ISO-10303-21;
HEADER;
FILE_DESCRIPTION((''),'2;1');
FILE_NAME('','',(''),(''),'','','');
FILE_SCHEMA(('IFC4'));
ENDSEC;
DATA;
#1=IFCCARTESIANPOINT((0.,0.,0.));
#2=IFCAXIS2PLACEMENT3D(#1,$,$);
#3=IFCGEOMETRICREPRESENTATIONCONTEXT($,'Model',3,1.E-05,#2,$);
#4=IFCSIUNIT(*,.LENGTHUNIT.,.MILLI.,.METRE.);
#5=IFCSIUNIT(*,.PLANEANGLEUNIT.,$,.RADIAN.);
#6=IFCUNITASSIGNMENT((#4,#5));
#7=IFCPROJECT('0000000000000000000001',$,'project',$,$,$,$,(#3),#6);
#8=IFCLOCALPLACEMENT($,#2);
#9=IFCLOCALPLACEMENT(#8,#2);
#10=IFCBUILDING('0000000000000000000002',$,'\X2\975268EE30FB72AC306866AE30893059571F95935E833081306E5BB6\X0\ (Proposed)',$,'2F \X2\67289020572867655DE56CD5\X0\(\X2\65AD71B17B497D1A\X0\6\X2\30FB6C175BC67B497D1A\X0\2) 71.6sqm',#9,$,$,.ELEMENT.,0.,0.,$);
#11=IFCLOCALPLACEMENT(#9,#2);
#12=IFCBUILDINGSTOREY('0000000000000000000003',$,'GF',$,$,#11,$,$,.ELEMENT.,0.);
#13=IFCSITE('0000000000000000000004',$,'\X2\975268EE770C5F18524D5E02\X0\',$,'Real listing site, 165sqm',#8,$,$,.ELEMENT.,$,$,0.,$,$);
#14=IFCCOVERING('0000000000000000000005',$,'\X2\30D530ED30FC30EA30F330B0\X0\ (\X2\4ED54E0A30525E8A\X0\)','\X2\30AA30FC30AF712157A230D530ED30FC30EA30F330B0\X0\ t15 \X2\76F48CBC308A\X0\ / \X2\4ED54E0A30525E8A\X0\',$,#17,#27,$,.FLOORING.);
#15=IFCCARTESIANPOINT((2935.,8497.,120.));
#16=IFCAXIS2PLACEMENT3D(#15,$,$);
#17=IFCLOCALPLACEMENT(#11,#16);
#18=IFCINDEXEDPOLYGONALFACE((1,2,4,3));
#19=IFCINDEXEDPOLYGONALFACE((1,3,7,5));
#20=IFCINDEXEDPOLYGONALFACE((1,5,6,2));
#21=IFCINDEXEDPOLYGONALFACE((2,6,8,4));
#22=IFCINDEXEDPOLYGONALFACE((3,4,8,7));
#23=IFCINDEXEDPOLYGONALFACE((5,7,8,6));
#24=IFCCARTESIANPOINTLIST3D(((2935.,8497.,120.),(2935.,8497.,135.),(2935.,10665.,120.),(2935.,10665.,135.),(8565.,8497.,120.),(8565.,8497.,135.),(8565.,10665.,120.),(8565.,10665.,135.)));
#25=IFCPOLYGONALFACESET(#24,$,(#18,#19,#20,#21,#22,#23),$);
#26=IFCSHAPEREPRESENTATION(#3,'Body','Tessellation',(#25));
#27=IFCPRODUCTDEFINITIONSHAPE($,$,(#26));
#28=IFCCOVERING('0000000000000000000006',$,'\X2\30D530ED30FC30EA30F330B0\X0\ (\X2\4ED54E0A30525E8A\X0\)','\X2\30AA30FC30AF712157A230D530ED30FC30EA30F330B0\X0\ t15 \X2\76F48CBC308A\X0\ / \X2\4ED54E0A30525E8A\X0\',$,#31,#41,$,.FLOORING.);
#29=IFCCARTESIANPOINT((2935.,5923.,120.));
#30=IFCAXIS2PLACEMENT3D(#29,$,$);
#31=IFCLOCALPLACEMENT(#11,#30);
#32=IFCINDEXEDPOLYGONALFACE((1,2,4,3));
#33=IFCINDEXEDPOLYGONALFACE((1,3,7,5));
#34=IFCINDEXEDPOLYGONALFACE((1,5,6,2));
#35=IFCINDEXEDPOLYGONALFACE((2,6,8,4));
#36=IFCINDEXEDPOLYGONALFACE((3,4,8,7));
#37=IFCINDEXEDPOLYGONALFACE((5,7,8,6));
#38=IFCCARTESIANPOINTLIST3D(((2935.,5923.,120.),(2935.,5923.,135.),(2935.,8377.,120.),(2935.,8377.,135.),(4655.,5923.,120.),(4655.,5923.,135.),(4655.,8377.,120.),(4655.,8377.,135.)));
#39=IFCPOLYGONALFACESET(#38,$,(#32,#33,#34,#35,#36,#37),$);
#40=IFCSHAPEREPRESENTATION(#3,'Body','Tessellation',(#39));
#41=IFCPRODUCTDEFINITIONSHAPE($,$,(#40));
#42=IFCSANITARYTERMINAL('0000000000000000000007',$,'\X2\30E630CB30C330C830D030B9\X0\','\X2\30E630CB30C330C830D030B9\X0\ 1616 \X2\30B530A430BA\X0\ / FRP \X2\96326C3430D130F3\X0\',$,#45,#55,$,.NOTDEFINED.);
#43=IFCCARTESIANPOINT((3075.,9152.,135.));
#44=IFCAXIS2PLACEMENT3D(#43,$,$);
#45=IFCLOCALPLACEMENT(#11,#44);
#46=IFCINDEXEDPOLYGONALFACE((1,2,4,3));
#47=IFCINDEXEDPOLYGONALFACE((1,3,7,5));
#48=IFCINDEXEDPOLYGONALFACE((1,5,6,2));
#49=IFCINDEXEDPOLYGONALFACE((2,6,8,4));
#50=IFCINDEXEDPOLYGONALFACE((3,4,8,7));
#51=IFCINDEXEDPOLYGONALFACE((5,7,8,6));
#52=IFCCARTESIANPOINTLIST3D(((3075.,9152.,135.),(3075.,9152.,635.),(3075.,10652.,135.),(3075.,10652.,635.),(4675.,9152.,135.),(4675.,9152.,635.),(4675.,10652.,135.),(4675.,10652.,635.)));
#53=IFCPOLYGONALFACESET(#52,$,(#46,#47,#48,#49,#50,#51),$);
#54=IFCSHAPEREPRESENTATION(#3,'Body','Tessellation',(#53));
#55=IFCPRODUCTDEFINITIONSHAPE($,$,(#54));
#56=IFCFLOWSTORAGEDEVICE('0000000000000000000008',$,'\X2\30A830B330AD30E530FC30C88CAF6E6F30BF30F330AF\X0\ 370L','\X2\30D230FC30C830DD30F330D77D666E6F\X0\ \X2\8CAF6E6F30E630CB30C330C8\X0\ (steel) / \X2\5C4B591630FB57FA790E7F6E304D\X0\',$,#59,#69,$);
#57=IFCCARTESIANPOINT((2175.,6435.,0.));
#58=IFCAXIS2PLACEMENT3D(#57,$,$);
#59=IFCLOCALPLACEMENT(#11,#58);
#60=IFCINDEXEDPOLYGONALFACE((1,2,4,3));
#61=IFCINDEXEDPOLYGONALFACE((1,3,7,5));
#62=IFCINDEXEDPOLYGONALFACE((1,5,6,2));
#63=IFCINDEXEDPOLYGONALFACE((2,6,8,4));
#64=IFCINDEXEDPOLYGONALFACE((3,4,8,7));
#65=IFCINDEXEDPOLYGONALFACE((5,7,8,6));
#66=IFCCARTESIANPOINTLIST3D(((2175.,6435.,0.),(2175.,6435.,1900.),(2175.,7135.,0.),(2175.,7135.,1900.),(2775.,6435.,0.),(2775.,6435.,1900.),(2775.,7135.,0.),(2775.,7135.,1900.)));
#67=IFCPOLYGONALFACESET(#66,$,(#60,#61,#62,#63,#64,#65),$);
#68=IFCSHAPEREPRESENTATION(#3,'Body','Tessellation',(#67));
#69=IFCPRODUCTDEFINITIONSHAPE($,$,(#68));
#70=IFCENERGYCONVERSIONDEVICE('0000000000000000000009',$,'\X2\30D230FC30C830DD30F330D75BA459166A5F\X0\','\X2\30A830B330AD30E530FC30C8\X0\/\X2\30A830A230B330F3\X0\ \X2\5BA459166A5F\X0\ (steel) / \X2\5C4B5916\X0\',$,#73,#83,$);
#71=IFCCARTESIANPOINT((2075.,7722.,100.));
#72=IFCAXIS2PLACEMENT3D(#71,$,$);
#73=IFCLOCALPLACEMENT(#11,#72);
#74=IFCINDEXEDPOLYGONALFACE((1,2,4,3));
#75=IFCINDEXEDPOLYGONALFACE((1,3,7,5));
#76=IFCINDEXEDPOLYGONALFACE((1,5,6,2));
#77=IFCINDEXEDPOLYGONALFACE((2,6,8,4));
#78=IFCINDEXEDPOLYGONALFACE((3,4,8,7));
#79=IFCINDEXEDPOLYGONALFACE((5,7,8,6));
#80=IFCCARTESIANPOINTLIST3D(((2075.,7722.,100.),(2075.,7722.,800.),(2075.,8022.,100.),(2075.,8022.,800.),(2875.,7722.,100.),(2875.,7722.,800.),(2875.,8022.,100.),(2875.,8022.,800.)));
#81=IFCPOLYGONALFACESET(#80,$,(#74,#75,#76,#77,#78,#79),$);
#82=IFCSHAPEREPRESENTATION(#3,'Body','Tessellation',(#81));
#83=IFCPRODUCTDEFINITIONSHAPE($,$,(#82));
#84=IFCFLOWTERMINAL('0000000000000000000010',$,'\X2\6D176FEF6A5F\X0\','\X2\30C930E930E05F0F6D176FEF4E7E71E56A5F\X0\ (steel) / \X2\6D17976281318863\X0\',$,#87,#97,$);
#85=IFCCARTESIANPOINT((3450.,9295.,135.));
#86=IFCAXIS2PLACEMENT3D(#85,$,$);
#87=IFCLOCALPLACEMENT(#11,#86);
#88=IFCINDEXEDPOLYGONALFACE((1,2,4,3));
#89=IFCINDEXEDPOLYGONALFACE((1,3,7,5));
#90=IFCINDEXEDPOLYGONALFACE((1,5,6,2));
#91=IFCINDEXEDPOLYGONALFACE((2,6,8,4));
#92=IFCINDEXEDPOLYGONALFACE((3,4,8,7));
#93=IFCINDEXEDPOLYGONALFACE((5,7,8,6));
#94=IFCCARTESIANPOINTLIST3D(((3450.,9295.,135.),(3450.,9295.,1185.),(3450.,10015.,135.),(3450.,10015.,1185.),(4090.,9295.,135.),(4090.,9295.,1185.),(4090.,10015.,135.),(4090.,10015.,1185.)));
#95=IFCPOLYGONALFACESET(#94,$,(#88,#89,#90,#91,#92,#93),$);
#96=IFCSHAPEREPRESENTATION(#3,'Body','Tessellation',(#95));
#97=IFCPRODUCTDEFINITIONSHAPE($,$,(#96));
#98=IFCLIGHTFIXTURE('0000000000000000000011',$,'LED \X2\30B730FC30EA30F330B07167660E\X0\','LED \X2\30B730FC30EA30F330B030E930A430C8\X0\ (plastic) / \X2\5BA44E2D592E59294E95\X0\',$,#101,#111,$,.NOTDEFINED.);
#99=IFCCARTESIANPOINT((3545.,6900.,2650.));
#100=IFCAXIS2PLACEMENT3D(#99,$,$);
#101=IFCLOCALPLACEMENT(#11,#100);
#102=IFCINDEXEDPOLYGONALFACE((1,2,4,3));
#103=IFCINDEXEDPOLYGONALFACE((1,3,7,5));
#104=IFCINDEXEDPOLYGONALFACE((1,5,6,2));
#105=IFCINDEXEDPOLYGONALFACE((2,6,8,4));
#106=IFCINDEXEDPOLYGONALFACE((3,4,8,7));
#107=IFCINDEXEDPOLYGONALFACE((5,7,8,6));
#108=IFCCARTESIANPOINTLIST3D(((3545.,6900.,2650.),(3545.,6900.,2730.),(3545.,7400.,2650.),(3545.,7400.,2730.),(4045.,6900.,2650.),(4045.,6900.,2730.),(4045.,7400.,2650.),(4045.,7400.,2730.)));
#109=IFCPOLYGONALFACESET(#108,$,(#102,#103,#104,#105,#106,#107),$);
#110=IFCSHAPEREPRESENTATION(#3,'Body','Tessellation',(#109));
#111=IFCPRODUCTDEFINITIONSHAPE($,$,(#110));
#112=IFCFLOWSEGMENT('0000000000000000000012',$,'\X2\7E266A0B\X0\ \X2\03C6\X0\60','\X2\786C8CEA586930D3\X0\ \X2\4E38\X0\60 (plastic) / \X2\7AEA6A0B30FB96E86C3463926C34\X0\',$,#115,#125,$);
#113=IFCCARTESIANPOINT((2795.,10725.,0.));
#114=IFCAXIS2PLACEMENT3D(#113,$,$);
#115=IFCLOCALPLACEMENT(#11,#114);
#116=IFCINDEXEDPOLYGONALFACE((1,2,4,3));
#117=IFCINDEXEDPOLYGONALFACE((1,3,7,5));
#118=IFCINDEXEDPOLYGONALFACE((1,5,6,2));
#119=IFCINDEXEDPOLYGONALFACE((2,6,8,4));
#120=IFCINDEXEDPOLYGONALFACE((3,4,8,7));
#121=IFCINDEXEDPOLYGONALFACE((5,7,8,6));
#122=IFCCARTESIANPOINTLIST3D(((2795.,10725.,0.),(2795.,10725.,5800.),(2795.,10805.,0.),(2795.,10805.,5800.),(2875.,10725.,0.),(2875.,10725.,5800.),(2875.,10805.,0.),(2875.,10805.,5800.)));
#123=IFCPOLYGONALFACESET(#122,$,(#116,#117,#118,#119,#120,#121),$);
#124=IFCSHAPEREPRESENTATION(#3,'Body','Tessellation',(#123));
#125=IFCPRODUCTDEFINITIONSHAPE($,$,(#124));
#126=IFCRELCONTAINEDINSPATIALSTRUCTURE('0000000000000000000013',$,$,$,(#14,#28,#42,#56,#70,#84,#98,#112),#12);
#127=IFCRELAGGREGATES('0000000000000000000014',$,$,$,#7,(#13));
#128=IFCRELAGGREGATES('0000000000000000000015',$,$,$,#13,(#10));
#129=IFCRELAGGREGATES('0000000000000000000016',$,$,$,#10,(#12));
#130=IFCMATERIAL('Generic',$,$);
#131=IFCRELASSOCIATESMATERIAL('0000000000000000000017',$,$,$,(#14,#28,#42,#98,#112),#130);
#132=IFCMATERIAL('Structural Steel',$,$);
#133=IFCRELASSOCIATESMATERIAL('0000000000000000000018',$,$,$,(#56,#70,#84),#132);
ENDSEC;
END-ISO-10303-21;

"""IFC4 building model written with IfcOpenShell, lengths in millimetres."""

from ifc_helpers import new_model, si_unit, frame, frame_2d, origin, place, context, project, spatial, rectangle, extrude, material, element, save


model = new_model("IFC4")

# Units and contexts
model_context = context("Model", 3, precision=1e-05, world=origin())
ifc_project = project(units=[si_unit("LENGTHUNIT", "METRE", prefix="MILLI"), si_unit("PLANEANGLEUNIT", "RADIAN")], contexts=[model_context])

# Site, building, storey
site_placement = place(None, origin())
site = spatial("IfcSite", under=ifc_project, at=site_placement, Name="青森県弘前市", ObjectType="Real listing site, 165sqm", CompositionType="ELEMENT", RefElevation=0.0)
building_placement = place(site_placement, origin())
building = spatial("IfcBuilding", under=site, at=building_placement, Name="青森・犬と暮らす土間広めの家 (Proposed)", ObjectType="2F 木造在来工法(断熱等級6・気密等級2) 71.6sqm", CompositionType="ELEMENT", ElevationOfRefHeight=0.0, ElevationOfTerrain=0.0)
storey_placement = place(building_placement, origin())
storey = spatial("IfcBuildingStorey", under=building, at=storey_placement, Name="GF", CompositionType="ELEMENT", Elevation=0.0)

# Coverings
ifc_material_1 = material(Name="Generic")
covering_1_placement = place(storey_placement, frame((2935.0, 8497.0, 120.0)))
element("IfcCovering", 1, at=covering_1_placement, inside=storey, material=ifc_material_1, Name="フローリング (仕上げ床)", Description="オーク無垢フローリング t15 直貼り / 仕上げ床", PredefinedType="FLOORING", context=model_context, shape_type="SweptSolid", body=[
    extrude(rectangle(XDim=5630.0, YDim=2168.0, at=frame_2d((2815.0, 1084.0))), frame((2935.0, 8497.0, 120.0)), (0.0, 0.0, 1.0), 15.0),
])
covering_2_placement = place(storey_placement, frame((2935.0, 5923.0, 120.0)))
element("IfcCovering", 2, at=covering_2_placement, inside=storey, material=ifc_material_1, Name="フローリング (仕上げ床)", Description="オーク無垢フローリング t15 直貼り / 仕上げ床", PredefinedType="FLOORING", context=model_context, shape_type="SweptSolid", body=[
    extrude(rectangle(XDim=1720.0, YDim=2454.0, at=frame_2d((860.0, 1227.0))), frame((2935.0, 5923.0, 120.0)), (0.0, 0.0, 1.0), 15.0),
])

# Sanitary terminal
sanitary_terminal_placement = place(storey_placement, frame((3075.0, 9152.0, 135.0)))
element("IfcSanitaryTerminal", 3, at=sanitary_terminal_placement, inside=storey, material=ifc_material_1, Name="ユニットバス", Description="ユニットバス 1616 サイズ / FRP 防水パン", PredefinedType="NOTDEFINED", context=model_context, shape_type="SweptSolid", body=[
    extrude(rectangle(XDim=1600.0, YDim=1500.0, at=frame_2d((800.0, 750.0))), frame((3075.0, 9152.0, 135.0)), (0.0, 0.0, 1.0), 500.0),
])

# Flow storage device
ifc_material_2 = material(Name="Structural Steel")
flow_storage_device_placement = place(storey_placement, frame((2175.0, 6435.0, 0.0)))
element("IfcFlowStorageDevice", 4, at=flow_storage_device_placement, inside=storey, material=ifc_material_2, Name="エコキュート貯湯タンク 370L", Description="ヒートポンプ給湯 貯湯ユニット (steel) / 屋外・基礎置き", context=model_context, shape_type="SweptSolid", body=[
    extrude(rectangle(XDim=600.0, YDim=700.0, at=frame_2d((300.0, 350.0))), frame((2175.0, 6435.0, 0.0)), (0.0, 0.0, 1.0), 1900.0),
])

# Energy conversion device
energy_conversion_device_placement = place(storey_placement, frame((2075.0, 7722.0, 100.0)))
element("IfcEnergyConversionDevice", 5, at=energy_conversion_device_placement, inside=storey, material=ifc_material_2, Name="ヒートポンプ室外機", Description="エコキュート/エアコン 室外機 (steel) / 屋外", context=model_context, shape_type="SweptSolid", body=[
    extrude(rectangle(XDim=800.0, YDim=300.0, at=frame_2d((400.0, 150.0))), frame((2075.0, 7722.0, 100.0)), (0.0, 0.0, 1.0), 700.0),
])

# Flow terminal
flow_terminal_placement = place(storey_placement, frame((3450.0, 9295.0, 135.0)))
element("IfcFlowTerminal", 6, at=flow_terminal_placement, inside=storey, material=ifc_material_2, Name="洗濯機", Description="ドラム式洗濯乾燥機 (steel) / 洗面脱衣", context=model_context, shape_type="SweptSolid", body=[
    extrude(rectangle(XDim=640.0, YDim=720.0, at=frame_2d((320.0, 360.0))), frame((3450.0, 9295.0, 135.0)), (0.0, 0.0, 1.0), 1050.0),
])

# Light fixture
light_fixture_placement = place(storey_placement, frame((3545.0, 6900.0, 2650.0)))
element("IfcLightFixture", 7, at=light_fixture_placement, inside=storey, material=ifc_material_1, Name="LED シーリング照明", Description="LED シーリングライト (plastic) / 室中央天井", PredefinedType="NOTDEFINED", context=model_context, shape_type="SweptSolid", body=[
    extrude(rectangle(XDim=500.0, YDim=500.0, at=frame_2d((250.0, 250.0))), frame((3545.0, 6900.0, 2650.0)), (0.0, 0.0, 1.0), 80.0),
])

# Flow segment
flow_segment_placement = place(storey_placement, frame((2795.0, 10725.0, 0.0)))
element("IfcFlowSegment", 8, at=flow_segment_placement, inside=storey, material=ifc_material_1, Name="縦樋 φ60", Description="硬質塩ビ 丸60 (plastic) / 竪樋・雨水排水", context=model_context, shape_type="SweptSolid", body=[
    extrude(rectangle(XDim=80.0, YDim=80.0, at=frame_2d((40.0, 40.0))), frame((2795.0, 10725.0, 0.0)), (0.0, 0.0, 1.0), 5800.0),
])

save(model, "model.ifc")
